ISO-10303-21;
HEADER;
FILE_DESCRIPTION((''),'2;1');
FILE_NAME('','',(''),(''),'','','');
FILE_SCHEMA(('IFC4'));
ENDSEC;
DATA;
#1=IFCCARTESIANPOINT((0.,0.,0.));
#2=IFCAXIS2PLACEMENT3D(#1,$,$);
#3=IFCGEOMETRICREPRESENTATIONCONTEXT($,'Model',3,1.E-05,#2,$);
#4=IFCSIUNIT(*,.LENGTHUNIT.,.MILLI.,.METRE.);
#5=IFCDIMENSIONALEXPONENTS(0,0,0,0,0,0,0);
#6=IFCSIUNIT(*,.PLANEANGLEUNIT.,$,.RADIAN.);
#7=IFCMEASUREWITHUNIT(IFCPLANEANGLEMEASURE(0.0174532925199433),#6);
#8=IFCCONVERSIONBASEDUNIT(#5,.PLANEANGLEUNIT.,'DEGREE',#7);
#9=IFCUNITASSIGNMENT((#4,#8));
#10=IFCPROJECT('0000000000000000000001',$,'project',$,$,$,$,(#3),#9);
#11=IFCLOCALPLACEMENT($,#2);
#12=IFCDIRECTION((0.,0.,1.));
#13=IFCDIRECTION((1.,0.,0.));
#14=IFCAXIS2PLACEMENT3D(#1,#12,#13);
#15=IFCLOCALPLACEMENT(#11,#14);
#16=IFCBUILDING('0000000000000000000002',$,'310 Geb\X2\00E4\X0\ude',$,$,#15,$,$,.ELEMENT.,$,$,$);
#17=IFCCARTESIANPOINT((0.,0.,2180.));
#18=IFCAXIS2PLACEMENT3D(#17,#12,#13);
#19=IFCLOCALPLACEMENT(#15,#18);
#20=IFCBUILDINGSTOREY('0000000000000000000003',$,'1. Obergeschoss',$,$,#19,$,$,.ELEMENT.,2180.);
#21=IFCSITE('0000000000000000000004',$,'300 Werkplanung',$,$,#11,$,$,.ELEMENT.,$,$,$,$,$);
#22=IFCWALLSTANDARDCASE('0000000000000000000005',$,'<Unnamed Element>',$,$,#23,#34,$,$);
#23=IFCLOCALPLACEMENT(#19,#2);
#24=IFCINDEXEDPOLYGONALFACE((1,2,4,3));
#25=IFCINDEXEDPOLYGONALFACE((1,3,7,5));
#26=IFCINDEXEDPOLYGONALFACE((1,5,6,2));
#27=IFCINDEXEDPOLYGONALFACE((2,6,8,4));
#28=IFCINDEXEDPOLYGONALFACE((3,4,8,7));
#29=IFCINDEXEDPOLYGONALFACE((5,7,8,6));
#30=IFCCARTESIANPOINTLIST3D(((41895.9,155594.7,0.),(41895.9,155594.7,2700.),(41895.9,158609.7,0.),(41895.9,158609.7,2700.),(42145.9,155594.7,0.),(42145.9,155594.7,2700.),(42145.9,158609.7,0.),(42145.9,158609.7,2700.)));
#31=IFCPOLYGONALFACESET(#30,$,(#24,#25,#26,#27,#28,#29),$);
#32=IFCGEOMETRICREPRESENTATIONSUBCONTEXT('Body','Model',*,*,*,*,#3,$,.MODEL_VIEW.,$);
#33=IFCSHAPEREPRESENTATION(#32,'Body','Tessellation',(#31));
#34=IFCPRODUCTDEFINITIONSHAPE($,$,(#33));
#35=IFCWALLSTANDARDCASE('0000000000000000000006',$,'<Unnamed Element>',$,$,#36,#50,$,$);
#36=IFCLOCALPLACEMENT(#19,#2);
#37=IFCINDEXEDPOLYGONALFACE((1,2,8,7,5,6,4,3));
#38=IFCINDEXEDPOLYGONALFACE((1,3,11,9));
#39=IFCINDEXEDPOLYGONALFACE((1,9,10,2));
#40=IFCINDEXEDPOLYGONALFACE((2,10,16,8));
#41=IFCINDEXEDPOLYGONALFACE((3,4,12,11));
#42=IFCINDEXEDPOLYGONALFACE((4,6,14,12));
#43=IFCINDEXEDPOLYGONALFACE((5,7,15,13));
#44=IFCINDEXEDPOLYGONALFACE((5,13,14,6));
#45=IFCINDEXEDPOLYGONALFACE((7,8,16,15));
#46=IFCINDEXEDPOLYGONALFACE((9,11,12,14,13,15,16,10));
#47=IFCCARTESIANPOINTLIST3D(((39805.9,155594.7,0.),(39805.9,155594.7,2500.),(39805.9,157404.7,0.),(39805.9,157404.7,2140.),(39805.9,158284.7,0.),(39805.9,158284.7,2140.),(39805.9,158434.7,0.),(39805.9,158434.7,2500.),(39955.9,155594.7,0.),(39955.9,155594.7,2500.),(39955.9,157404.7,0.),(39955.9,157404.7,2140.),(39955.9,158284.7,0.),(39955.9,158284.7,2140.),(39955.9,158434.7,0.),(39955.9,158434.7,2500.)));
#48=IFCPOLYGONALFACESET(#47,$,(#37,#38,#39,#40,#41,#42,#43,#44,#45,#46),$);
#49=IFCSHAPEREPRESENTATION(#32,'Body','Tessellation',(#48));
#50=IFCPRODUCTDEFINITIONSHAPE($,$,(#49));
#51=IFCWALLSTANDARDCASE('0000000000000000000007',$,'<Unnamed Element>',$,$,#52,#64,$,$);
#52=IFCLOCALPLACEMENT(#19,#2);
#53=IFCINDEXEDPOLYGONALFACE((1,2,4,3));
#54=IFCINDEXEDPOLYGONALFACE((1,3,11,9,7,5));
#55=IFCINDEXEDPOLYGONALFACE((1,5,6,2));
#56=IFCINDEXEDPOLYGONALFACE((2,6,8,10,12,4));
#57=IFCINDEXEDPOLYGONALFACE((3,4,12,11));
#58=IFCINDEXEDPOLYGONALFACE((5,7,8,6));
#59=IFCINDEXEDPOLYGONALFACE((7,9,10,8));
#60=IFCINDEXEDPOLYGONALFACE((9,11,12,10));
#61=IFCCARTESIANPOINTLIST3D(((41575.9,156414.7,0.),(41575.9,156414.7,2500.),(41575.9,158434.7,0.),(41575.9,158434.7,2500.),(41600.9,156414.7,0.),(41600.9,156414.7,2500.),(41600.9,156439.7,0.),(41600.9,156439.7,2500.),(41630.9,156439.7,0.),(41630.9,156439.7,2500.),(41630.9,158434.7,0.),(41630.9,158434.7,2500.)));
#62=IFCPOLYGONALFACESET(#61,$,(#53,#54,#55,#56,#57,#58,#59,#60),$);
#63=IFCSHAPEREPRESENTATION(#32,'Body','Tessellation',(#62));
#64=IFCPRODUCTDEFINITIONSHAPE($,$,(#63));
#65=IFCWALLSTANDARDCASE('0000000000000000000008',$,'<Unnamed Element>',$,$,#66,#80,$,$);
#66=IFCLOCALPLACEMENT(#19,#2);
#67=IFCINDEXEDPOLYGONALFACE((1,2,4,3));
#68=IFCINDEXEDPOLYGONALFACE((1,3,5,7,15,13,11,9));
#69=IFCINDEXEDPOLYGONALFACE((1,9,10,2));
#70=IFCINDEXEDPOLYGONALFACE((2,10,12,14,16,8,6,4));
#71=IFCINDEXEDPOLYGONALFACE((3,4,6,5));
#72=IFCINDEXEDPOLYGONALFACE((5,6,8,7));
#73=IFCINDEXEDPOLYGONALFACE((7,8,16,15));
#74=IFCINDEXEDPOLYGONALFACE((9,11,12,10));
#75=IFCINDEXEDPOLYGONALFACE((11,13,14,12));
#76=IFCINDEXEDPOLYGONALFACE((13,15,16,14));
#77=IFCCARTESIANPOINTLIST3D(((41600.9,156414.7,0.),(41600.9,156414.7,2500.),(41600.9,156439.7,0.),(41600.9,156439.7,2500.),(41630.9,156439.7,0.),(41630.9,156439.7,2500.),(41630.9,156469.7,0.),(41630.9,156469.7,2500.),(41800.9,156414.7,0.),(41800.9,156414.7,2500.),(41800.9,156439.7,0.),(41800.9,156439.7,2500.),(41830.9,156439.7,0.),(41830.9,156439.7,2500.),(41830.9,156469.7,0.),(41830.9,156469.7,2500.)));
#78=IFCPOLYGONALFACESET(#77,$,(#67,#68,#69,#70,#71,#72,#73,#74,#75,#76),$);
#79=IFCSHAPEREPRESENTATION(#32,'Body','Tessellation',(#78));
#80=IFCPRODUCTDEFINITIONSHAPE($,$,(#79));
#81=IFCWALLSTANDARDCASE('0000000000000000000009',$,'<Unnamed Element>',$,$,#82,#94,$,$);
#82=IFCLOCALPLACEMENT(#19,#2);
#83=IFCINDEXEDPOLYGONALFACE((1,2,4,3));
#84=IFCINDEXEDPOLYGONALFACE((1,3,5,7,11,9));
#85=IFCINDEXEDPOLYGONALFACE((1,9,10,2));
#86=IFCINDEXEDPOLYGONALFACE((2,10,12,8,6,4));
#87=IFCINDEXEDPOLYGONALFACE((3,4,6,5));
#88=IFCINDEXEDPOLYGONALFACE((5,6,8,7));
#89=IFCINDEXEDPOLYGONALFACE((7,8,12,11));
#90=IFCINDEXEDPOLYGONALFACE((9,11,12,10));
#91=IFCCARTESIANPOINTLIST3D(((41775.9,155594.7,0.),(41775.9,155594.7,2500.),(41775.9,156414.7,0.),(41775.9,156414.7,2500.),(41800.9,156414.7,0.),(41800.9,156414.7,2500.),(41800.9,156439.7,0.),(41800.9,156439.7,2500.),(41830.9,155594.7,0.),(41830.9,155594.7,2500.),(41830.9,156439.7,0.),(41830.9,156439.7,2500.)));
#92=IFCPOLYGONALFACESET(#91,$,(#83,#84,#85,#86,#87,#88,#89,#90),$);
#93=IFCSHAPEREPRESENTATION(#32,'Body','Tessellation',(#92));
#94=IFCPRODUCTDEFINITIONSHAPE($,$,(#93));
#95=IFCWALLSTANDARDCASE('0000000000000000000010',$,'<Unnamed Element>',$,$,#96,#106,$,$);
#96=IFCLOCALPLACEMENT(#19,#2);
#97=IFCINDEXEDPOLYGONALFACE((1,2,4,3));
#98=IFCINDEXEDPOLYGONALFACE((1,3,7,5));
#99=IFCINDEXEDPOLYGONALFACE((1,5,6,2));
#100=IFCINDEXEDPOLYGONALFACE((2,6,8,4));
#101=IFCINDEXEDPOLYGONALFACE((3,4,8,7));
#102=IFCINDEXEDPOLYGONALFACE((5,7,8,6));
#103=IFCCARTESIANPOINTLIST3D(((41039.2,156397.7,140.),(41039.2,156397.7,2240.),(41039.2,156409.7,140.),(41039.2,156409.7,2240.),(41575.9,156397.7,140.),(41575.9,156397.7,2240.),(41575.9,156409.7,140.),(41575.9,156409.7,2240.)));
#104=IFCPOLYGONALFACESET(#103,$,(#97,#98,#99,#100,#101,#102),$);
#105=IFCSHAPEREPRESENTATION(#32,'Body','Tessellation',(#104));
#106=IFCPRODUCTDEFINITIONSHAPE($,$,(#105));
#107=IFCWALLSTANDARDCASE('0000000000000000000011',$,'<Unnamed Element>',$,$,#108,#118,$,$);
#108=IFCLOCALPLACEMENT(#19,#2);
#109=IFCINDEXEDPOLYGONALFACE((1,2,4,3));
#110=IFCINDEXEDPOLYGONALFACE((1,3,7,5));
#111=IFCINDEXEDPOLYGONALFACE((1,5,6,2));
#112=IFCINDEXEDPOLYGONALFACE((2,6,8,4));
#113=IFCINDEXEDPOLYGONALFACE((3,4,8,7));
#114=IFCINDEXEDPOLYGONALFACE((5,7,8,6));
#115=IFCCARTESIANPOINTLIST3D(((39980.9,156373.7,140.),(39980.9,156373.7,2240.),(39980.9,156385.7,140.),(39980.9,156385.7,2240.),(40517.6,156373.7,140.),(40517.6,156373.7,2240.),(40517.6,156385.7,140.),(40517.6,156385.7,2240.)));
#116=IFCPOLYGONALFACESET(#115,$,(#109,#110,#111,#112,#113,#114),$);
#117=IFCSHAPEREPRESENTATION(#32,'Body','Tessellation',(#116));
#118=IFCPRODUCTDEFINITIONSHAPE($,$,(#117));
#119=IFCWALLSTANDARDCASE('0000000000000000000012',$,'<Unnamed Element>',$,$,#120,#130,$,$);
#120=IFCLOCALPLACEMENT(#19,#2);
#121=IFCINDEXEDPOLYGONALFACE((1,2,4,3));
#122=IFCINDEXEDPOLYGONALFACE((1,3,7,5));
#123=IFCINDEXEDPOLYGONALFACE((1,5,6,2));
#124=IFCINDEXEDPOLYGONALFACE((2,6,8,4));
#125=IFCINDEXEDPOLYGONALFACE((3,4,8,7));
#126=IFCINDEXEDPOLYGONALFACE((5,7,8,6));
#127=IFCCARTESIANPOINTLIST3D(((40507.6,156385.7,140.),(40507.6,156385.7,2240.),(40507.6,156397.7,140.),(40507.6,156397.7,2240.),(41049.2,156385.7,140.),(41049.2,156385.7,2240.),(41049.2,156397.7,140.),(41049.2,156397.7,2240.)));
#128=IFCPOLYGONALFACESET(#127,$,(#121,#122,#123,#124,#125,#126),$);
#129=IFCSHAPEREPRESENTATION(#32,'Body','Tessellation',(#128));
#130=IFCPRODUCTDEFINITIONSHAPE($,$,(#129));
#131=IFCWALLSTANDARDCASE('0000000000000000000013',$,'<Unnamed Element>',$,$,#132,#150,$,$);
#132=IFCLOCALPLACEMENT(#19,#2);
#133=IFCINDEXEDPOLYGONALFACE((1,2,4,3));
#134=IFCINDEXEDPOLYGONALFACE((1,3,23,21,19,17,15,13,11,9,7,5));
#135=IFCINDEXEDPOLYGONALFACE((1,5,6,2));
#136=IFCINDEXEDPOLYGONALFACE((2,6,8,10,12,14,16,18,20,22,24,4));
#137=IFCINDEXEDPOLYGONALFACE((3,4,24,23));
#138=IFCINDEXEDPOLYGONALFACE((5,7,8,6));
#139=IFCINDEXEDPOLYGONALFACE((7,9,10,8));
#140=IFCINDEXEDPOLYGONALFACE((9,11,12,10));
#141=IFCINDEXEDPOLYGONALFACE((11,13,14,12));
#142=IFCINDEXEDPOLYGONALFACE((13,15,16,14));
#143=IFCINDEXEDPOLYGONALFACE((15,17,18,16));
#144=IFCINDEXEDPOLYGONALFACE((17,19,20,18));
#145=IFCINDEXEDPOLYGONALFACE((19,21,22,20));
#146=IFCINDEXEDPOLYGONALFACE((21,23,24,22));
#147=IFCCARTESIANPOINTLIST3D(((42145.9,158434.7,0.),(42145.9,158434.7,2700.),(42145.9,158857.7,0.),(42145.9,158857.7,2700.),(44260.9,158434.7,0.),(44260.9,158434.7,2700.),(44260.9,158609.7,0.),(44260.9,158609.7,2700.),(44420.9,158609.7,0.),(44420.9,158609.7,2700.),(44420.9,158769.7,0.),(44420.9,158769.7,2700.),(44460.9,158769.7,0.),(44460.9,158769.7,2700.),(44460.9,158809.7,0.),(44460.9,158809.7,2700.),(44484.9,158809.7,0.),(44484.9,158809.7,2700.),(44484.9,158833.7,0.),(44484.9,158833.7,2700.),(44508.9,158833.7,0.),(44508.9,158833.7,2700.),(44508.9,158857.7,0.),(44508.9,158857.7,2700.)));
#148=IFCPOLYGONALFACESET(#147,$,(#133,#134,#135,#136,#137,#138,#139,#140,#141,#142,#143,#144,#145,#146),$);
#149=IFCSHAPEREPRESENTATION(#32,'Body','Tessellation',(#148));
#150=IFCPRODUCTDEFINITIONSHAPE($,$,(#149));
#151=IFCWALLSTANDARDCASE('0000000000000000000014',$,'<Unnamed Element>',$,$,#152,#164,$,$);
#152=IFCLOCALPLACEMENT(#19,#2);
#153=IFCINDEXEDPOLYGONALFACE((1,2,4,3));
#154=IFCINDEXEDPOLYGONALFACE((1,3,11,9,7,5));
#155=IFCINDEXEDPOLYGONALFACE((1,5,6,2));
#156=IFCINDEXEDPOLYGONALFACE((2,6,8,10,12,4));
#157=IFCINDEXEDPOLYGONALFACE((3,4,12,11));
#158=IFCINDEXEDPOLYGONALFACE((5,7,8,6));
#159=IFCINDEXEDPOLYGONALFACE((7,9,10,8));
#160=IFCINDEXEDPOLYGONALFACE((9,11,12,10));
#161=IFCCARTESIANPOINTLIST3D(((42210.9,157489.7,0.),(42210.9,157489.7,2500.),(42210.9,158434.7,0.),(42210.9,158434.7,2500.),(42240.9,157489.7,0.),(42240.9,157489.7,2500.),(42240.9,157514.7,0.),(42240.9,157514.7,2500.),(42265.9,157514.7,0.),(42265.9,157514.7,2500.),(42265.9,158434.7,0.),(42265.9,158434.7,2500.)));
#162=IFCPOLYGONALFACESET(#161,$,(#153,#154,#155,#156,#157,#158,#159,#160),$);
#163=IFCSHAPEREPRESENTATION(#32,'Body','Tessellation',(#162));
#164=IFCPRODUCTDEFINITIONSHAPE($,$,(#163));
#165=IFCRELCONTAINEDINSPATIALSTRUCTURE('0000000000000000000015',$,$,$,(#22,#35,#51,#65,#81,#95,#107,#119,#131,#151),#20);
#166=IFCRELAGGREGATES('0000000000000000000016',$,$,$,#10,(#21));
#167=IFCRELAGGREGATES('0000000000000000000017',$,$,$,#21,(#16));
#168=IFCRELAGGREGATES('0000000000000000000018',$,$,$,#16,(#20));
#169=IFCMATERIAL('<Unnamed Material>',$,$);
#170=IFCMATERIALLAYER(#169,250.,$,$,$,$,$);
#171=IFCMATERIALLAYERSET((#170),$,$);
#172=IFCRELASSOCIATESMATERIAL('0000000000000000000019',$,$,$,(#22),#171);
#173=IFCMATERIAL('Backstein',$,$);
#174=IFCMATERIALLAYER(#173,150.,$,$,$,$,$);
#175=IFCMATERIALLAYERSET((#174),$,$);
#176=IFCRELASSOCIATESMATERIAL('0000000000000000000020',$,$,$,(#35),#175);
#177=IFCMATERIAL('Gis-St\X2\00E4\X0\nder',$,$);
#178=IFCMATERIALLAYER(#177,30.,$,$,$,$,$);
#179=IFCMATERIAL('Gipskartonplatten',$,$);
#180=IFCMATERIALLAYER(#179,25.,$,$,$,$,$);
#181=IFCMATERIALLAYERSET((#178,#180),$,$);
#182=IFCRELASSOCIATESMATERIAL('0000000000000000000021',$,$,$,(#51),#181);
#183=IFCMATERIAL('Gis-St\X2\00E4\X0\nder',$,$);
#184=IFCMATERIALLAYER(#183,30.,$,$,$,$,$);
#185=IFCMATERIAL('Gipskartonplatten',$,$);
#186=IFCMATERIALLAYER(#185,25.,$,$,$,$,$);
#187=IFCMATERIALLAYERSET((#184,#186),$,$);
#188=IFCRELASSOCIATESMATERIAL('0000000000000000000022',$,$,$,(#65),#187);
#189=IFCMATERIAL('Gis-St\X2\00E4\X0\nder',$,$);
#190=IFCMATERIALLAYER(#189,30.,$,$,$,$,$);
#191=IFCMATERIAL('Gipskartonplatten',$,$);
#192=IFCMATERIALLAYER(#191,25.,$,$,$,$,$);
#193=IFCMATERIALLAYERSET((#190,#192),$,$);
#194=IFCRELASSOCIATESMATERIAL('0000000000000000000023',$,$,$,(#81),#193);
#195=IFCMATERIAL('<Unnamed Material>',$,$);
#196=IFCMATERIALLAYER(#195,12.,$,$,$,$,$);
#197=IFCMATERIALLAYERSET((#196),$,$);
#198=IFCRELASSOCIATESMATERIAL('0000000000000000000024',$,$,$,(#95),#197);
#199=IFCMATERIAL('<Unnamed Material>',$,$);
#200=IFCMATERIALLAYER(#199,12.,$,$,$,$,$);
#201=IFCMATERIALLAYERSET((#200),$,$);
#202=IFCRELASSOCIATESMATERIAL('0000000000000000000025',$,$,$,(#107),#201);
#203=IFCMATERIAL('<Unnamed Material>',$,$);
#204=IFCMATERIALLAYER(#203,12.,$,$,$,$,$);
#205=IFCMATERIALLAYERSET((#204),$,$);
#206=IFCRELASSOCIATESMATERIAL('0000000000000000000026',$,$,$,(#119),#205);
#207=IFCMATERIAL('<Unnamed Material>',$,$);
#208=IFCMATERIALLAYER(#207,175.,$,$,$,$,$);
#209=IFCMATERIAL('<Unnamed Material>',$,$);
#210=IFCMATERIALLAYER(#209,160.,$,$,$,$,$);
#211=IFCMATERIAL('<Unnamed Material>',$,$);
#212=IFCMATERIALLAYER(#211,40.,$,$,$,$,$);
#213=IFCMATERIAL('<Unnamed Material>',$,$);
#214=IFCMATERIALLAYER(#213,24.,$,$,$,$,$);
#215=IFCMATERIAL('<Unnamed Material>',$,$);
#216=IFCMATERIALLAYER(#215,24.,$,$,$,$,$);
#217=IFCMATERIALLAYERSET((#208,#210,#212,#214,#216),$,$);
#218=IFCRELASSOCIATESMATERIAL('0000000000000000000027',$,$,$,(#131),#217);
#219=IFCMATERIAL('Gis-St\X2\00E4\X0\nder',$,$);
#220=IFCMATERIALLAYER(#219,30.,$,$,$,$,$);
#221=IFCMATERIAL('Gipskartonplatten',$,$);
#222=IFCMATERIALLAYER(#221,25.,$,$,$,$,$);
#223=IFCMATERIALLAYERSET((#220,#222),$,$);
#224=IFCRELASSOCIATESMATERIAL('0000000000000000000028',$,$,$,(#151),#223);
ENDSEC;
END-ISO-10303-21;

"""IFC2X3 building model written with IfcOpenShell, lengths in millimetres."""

from ifc_helpers import new_model, entity, si_unit, converted_unit, frame, frame_2d, origin, origin_with_axes, place, context, subcontext, project, spatial, polyline, rectangle, outline, extrude, material, layer, layer_set, layer_usage, element, save


model = new_model("IFC2X3")

# Units and contexts
model_context = context("Model", 3, precision=1e-05, world=origin())
body_context = subcontext(model_context, "Body", "Model", "MODEL_VIEW")
ifc_project = project(units=[si_unit("LENGTHUNIT", "METRE", prefix="MILLI"), converted_unit("PLANEANGLEUNIT", "DEGREE", entity("IfcPlaneAngleMeasure", 0.0174532925199433), si_unit("PLANEANGLEUNIT", "RADIAN"), dimensions=[0, 0, 0, 0, 0, 0, 0])], contexts=[model_context])

# Site, building, storey
site_placement = place(None, origin())
site = spatial("IfcSite", under=ifc_project, at=site_placement, Name="300 Werkplanung", CompositionType="ELEMENT")
building_placement = place(site_placement, origin_with_axes())
building = spatial("IfcBuilding", under=site, at=building_placement, Name="310 Gebäude", CompositionType="ELEMENT")
storey_placement = place(building_placement, frame((0.0, 0.0, 2180.0), z_axis=(0.0, 0.0, 1.0), x_axis=(1.0, 0.0, 0.0)))
storey = spatial("IfcBuildingStorey", under=building, at=storey_placement, Name="1. Obergeschoss", CompositionType="ELEMENT", Elevation=2180.0)

# Wall
ifc_material_1 = material(Name="<Unnamed Material>")
ifc_layer_1 = layer(ifc_material_1, 250.0)
ifc_layer_set_1 = layer_set([ifc_layer_1])
ifc_layer_usage_1 = layer_usage(ifc_layer_set_1, "AXIS2", "POSITIVE", -250.0)
wall_1_placement = place(storey_placement, frame((42145.9, 155594.7, 0.0), z_axis=(0.0, 0.0, 1.0), x_axis=(0.0, 1.0, 0.0)))
element("IfcWallStandardCase", 1, at=wall_1_placement, inside=storey, material=ifc_layer_usage_1, Name="<Unnamed Element>", context=body_context, shape_type="SweptSolid", body=[
    extrude(rectangle(XDim=3015.0, YDim=250.0, at=frame_2d((1507.5, 125.0), x_axis=(1.0, 0.0))), origin_with_axes(), (0.0, 0.0, 1.0), 2700.0),
])

# Wall, opening
ifc_material_2 = material(Name="Backstein")
ifc_layer_2 = layer(ifc_material_2, 150.0)
ifc_layer_set_2 = layer_set([ifc_layer_2])
ifc_layer_usage_2 = layer_usage(ifc_layer_set_2, "AXIS2", "POSITIVE", 0.0)
wall_2_placement = place(storey_placement, frame((39805.9, 158434.7, 0.0), z_axis=(0.0, 0.0, 1.0), x_axis=(0.0, -1.0, 0.0)))
wall_2 = element("IfcWallStandardCase", 2, at=wall_2_placement, inside=storey, material=ifc_layer_usage_2, Name="<Unnamed Element>", context=body_context, shape_type="SweptSolid", body=[
    extrude(rectangle(XDim=2840.0, YDim=150.0, at=frame_2d((1420.0, 75.0), x_axis=(1.0, 0.0))), origin_with_axes(), (0.0, 0.0, 1.0), 2500.0),
])
opening_placement = place(wall_2_placement, frame((150.0, 0.0, 0.0), z_axis=(0.0, 1.0, 0.0), x_axis=(0.0, 0.0, 1.0)))
element("IfcOpeningElement", 3, at=opening_placement, cuts=wall_2, ObjectType="Opening", context=body_context, shape_type="SweptSolid", body=[
    extrude(rectangle(XDim=2140.0, YDim=880.0, at=frame_2d((1070.0, 440.0), x_axis=(1.0, 0.0))), origin_with_axes(), (0.0, 0.0, 1.0), 150.0),
])

# Walls
ifc_material_3 = material(Name="Gis-Ständer")
ifc_layer_3 = layer(ifc_material_3, 30.0)
ifc_material_4 = material(Name="Gipskartonplatten")
ifc_layer_4 = layer(ifc_material_4, 25.0)
ifc_layer_set_3 = layer_set([ifc_layer_3, ifc_layer_4])
ifc_layer_usage_3 = layer_usage(ifc_layer_set_3, "AXIS2", "POSITIVE", -55.0)
wall_3_placement = place(storey_placement, frame((41630.9, 156439.7, 0.0), z_axis=(0.0, 0.0, 1.0), x_axis=(0.0, 1.0, 0.0)))
element("IfcWallStandardCase", 4, at=wall_3_placement, inside=storey, material=ifc_layer_usage_3, Name="<Unnamed Element>", context=body_context, shape_type="SweptSolid", body=[
    extrude(outline(polyline([(-25.0, 55.0), (-25.0, 30.0), (0.0, 30.0), (0.0, 0.0), (1995.0, 0.0), (1995.0, 55.0), (-25.0, 55.0)])), origin_with_axes(), (0.0, 0.0, 1.0), 2500.0),
])
ifc_material_5 = material(Name="Gis-Ständer")
ifc_layer_5 = layer(ifc_material_5, 30.0)
ifc_material_6 = material(Name="Gipskartonplatten")
ifc_layer_6 = layer(ifc_material_6, 25.0)
ifc_layer_set_4 = layer_set([ifc_layer_5, ifc_layer_6])
ifc_layer_usage_4 = layer_usage(ifc_layer_set_4, "AXIS2", "POSITIVE", -55.0)
wall_4_placement = place(storey_placement, frame((41830.9, 156469.7, 0.0), z_axis=(0.0, 0.0, 1.0), x_axis=(-1.0, 0.0, 0.0)))
element("IfcWallStandardCase", 5, at=wall_4_placement, inside=storey, material=ifc_layer_usage_4, Name="<Unnamed Element>", context=body_context, shape_type="SweptSolid", body=[
    extrude(outline(polyline([(0.0, 0.0), (200.0, 0.0), (200.0, 30.0), (230.0, 30.0), (230.0, 55.0), (30.0, 55.0), (30.0, 30.0), (0.0, 30.0), (0.0, 0.0)])), origin_with_axes(), (0.0, 0.0, 1.0), 2500.0),
])
ifc_material_7 = material(Name="Gis-Ständer")
ifc_layer_7 = layer(ifc_material_7, 30.0)
ifc_material_8 = material(Name="Gipskartonplatten")
ifc_layer_8 = layer(ifc_material_8, 25.0)
ifc_layer_set_5 = layer_set([ifc_layer_7, ifc_layer_8])
ifc_layer_usage_5 = layer_usage(ifc_layer_set_5, "AXIS2", "POSITIVE", -55.0)
wall_5_placement = place(storey_placement, frame((41830.9, 155594.7, 0.0), z_axis=(0.0, 0.0, 1.0), x_axis=(0.0, 1.0, 0.0)))
element("IfcWallStandardCase", 6, at=wall_5_placement, inside=storey, material=ifc_layer_usage_5, Name="<Unnamed Element>", context=body_context, shape_type="SweptSolid", body=[
    extrude(outline(polyline([(0.0, 0.0), (845.0, 0.0), (845.0, 30.0), (820.0, 30.0), (820.0, 55.0), (0.0, 55.0), (0.0, 0.0)])), origin_with_axes(), (0.0, 0.0, 1.0), 2500.0),
])
ifc_material_9 = material(Name="<Unnamed Material>")
ifc_layer_9 = layer(ifc_material_9, 12.0)
ifc_layer_set_6 = layer_set([ifc_layer_9])
ifc_layer_usage_6 = layer_usage(ifc_layer_set_6, "AXIS2", "POSITIVE", 0.0)
wall_6_placement = place(storey_placement, frame((41575.9, 156409.7, 140.0), z_axis=(0.0, 0.0, 1.0), x_axis=(-1.0, 0.0, 0.0)))
element("IfcWallStandardCase", 7, at=wall_6_placement, inside=storey, material=ifc_layer_usage_6, Name="<Unnamed Element>", context=body_context, shape_type="SweptSolid", body=[
    extrude(rectangle(XDim=536.7, YDim=12.0, at=frame_2d((268.3, 6.0), x_axis=(1.0, 0.0))), origin_with_axes(), (0.0, 0.0, 1.0), 2100.0),
])
ifc_material_10 = material(Name="<Unnamed Material>")
ifc_layer_10 = layer(ifc_material_10, 12.0)
ifc_layer_set_7 = layer_set([ifc_layer_10])
ifc_layer_usage_7 = layer_usage(ifc_layer_set_7, "AXIS2", "POSITIVE", 0.0)
wall_7_placement = place(storey_placement, frame((40517.6, 156385.7, 140.0), z_axis=(0.0, 0.0, 1.0), x_axis=(-1.0, 0.0, 0.0)))
element("IfcWallStandardCase", 8, at=wall_7_placement, inside=storey, material=ifc_layer_usage_7, Name="<Unnamed Element>", context=body_context, shape_type="SweptSolid", body=[
    extrude(rectangle(XDim=536.7, YDim=12.0, at=frame_2d((268.3, 6.0), x_axis=(1.0, 0.0))), origin_with_axes(), (0.0, 0.0, 1.0), 2100.0),
])
ifc_material_11 = material(Name="<Unnamed Material>")
ifc_layer_11 = layer(ifc_material_11, 12.0)
ifc_layer_set_8 = layer_set([ifc_layer_11])
ifc_layer_usage_8 = layer_usage(ifc_layer_set_8, "AXIS2", "POSITIVE", 0.0)
wall_8_placement = place(storey_placement, frame((41049.2, 156397.7, 140.0), z_axis=(0.0, 0.0, 1.0), x_axis=(-1.0, 0.0, 0.0)))
element("IfcWallStandardCase", 9, at=wall_8_placement, inside=storey, material=ifc_layer_usage_8, Name="<Unnamed Element>", context=body_context, shape_type="SweptSolid", body=[
    extrude(rectangle(XDim=541.7, YDim=12.0, at=frame_2d((270.8, 6.0), x_axis=(1.0, 0.0))), origin_with_axes(), (0.0, 0.0, 1.0), 2100.0),
])
ifc_material_12 = material(Name="<Unnamed Material>")
ifc_layer_12 = layer(ifc_material_12, 175.0)
ifc_material_13 = material(Name="<Unnamed Material>")
ifc_layer_13 = layer(ifc_material_13, 160.0)
ifc_material_14 = material(Name="<Unnamed Material>")
ifc_layer_14 = layer(ifc_material_14, 40.0)
ifc_material_15 = material(Name="<Unnamed Material>")
ifc_layer_15 = layer(ifc_material_15, 24.0)
ifc_material_16 = material(Name="<Unnamed Material>")
ifc_layer_16 = layer(ifc_material_16, 24.0)
ifc_layer_set_9 = layer_set([ifc_layer_12, ifc_layer_13, ifc_layer_14, ifc_layer_15, ifc_layer_16])
ifc_layer_usage_9 = layer_usage(ifc_layer_set_9, "AXIS2", "POSITIVE", -175.0)
wall_9_placement = place(storey_placement, frame((42145.9, 158434.7, 0.0), z_axis=(0.0, 0.0, 1.0), x_axis=(1.0, 0.0, 0.0)))
element("IfcWallStandardCase", 10, at=wall_9_placement, inside=storey, material=ifc_layer_usage_9, Name="<Unnamed Element>", context=body_context, shape_type="SweptSolid", body=[
    extrude(outline(polyline([(0.0, 0.0), (2115.0, 0.0), (2115.0, 175.0), (2275.0, 175.0), (2275.0, 335.0), (2315.0, 335.0), (2315.0, 375.0), (2339.0, 375.0), (2339.0, 399.0), (2363.0, 399.0), (2363.0, 423.0), (0.0, 423.0), (0.0, 0.0)])), origin_with_axes(), (0.0, 0.0, 1.0), 2700.0),
])
ifc_material_17 = material(Name="Gis-Ständer")
ifc_layer_17 = layer(ifc_material_17, 30.0)
ifc_material_18 = material(Name="Gipskartonplatten")
ifc_layer_18 = layer(ifc_material_18, 25.0)
ifc_layer_set_10 = layer_set([ifc_layer_17, ifc_layer_18])
ifc_layer_usage_10 = layer_usage(ifc_layer_set_10, "AXIS2", "POSITIVE", -55.0)
wall_10_placement = place(storey_placement, frame((42210.9, 158434.7, 0.0), z_axis=(0.0, 0.0, 1.0), x_axis=(0.0, -1.0, 0.0)))
element("IfcWallStandardCase", 11, at=wall_10_placement, inside=storey, material=ifc_layer_usage_10, Name="<Unnamed Element>", context=body_context, shape_type="SweptSolid", body=[
    extrude(outline(polyline([(0.0, 0.0), (945.0, 0.0), (945.0, 30.0), (920.0, 30.0), (920.0, 55.0), (0.0, 55.0), (0.0, 0.0)])), origin_with_axes(), (0.0, 0.0, 1.0), 2500.0),
])

save(model, "model.ifc")
